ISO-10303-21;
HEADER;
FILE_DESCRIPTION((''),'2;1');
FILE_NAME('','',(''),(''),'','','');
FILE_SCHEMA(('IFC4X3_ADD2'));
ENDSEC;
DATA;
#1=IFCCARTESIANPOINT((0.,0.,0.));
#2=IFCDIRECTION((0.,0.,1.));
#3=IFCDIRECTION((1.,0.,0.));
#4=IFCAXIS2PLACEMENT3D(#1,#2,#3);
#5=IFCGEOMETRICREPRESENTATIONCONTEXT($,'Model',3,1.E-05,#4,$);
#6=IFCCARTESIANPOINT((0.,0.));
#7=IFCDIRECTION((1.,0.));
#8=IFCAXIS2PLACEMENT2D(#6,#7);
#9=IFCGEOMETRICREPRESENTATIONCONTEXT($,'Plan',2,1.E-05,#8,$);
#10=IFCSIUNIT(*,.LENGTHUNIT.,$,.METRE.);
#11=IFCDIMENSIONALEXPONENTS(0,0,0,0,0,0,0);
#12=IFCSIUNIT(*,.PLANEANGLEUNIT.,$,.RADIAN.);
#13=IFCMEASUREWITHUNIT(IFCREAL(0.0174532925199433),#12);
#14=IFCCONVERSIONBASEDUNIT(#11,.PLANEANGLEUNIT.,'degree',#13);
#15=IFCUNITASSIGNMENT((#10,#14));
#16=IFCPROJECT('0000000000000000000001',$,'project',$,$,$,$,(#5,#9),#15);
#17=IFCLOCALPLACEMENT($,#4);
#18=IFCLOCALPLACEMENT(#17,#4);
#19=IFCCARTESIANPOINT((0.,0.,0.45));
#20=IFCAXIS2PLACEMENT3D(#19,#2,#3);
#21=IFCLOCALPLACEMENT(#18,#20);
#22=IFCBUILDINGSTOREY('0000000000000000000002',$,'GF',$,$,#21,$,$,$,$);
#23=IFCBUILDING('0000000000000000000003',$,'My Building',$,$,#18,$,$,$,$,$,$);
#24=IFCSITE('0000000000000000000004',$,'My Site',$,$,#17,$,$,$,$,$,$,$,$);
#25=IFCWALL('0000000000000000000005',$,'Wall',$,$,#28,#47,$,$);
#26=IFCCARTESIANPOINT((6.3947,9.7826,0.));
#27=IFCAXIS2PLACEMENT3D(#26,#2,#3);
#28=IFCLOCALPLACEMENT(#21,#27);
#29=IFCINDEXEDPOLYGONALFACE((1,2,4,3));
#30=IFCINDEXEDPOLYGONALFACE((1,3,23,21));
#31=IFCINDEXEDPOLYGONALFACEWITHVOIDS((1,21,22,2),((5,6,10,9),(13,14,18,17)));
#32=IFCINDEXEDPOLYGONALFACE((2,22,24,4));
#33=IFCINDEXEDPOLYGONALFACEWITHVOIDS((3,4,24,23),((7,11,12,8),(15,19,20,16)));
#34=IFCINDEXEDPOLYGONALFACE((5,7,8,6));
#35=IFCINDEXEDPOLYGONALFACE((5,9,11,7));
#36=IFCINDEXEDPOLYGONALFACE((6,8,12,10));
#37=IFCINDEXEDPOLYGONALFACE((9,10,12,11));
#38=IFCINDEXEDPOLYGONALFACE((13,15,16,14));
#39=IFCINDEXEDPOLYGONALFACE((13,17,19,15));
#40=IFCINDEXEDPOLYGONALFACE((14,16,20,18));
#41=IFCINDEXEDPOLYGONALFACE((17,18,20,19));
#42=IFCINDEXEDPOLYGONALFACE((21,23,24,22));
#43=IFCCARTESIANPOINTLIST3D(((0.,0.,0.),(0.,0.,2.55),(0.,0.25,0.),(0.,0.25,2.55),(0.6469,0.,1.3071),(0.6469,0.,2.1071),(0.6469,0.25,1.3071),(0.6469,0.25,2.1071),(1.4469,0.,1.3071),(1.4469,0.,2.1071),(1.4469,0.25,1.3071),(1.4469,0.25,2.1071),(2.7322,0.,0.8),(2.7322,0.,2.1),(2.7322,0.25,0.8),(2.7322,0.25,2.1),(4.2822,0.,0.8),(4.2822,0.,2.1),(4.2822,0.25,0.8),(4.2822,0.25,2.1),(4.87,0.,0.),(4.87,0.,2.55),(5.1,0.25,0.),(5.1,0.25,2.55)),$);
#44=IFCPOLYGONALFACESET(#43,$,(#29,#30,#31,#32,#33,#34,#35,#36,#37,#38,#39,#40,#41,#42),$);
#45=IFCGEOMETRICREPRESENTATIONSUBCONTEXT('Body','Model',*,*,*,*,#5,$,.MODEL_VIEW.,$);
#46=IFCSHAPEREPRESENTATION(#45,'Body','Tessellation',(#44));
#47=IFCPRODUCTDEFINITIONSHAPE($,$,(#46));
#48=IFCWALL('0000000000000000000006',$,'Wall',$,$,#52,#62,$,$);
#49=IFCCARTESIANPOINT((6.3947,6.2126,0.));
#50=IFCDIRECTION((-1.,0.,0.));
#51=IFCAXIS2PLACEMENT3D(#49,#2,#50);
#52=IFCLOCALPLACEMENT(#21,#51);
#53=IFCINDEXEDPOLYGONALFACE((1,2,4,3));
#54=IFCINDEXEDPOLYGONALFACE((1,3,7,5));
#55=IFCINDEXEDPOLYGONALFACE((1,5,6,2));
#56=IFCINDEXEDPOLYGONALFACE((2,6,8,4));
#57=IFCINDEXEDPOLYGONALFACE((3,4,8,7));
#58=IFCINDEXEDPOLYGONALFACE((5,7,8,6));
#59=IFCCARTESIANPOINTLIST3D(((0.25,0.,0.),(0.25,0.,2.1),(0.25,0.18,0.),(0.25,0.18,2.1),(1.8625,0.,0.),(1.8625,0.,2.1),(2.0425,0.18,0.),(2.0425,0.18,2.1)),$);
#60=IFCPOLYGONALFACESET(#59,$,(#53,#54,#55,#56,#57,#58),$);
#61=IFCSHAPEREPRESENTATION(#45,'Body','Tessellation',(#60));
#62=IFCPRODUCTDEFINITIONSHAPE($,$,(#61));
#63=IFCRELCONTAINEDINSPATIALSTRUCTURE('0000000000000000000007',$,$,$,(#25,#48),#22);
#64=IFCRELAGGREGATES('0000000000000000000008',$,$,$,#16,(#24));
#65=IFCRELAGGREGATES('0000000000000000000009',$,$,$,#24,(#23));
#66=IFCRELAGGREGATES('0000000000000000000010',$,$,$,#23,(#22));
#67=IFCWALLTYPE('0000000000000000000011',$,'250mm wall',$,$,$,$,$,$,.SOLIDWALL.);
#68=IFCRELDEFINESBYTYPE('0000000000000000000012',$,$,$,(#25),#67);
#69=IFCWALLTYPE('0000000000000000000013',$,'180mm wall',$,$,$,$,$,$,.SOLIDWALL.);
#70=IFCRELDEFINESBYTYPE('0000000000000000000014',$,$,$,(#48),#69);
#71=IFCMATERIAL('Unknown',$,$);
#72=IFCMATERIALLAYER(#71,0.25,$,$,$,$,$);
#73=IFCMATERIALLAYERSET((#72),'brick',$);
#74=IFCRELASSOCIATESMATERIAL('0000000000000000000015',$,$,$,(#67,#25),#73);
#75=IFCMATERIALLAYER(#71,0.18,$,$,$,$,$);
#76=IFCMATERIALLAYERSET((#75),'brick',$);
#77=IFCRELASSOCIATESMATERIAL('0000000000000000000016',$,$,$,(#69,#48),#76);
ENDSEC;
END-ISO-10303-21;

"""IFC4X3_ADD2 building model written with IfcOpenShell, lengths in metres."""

from ifc_helpers import new_model, entity, si_unit, converted_unit, frame, origin_with_axes, origin_2d_with_axis, place, context, subcontext, project, spatial, line, indexed_curve, outline, extrude, source, transform, mapped, material, layer, layer_set, layer_usage, type_object, element, save


model = new_model("IFC4X3_ADD2")

# Units and contexts
model_context = context("Model", 3, precision=1e-05, world=origin_with_axes())
plan_context = context("Plan", 2, precision=1e-05, world=origin_2d_with_axis())
body_context_1 = subcontext(model_context, "Body", "Model", "MODEL_VIEW")
ifc_project = project(units=[si_unit("LENGTHUNIT", "METRE"), converted_unit("PLANEANGLEUNIT", "degree", entity("IfcReal", 0.0174532925199433), si_unit("PLANEANGLEUNIT", "RADIAN"), dimensions=[0, 0, 0, 0, 0, 0, 0])], contexts=[model_context, plan_context])

# Site, building, storey
site_placement = place(None, origin_with_axes())
site = spatial("IfcSite", under=ifc_project, at=site_placement, Name="My Site")
building_placement = place(site_placement, origin_with_axes())
building = spatial("IfcBuilding", under=site, at=building_placement, Name="My Building")
storey_placement = place(building_placement, frame((0.0, 0.0, 0.45), z_axis=(0.0, 0.0, 1.0), x_axis=(1.0, 0.0, 0.0)))
storey = spatial("IfcBuildingStorey", under=building, at=storey_placement, Name="GF")

# Wall, openings
ifc_material_1 = material(Name="Unknown")
ifc_layer_1 = layer(ifc_material_1, 0.25)
ifc_layer_set_1 = layer_set([ifc_layer_1], Name="brick")
ifc_layer_usage_1 = layer_usage(ifc_layer_set_1, "AXIS2", "POSITIVE", 0.0)
wall_type_1 = type_object("IfcWallType", Name="250mm wall", PredefinedType="SOLIDWALL", material=ifc_layer_set_1)
wall_1_placement = place(storey_placement, frame((6.3947, 9.7826, 0.0), z_axis=(0.0, 0.0, 1.0), x_axis=(1.0, 0.0, 0.0)))
wall_1 = element("IfcWall", 1, at=wall_1_placement, inside=storey, type_object=wall_type_1, material=ifc_layer_usage_1, Name="Wall", context=body_context_1, shape_type="SweptSolid", body=[
    extrude(outline(indexed_curve([(0.0, 0.0), (0.0, 0.25), (5.1, 0.25), (4.87, 0.0)], segments=[line(1, 2, 3, 4, 1)])), origin_with_axes(), (0.0, 0.0, 1.0), 2.55),
])
shared_shape_1 = source(origin_with_axes(), body_context_1, "Body", "SweptSolid", [
    extrude(outline(indexed_curve([(0.0, 0.0), (1.55, 0.0), (1.55, 1.3), (0.0, 1.3)], segments=[line(1, 2, 3, 4, 1)])), frame((-0.775, -0.6, 0.0), z_axis=(0.0, -1.0, 0.0), x_axis=(1.0, 0.0, 0.0)), (0.0, 0.0, -1.0), 1.2),
])
opening_1_placement = place(wall_1_placement, frame((3.5072, 0.2257, 0.8), z_axis=(0.0, 0.0, 1.0), x_axis=(-1.0, 0.0, 0.0)))
element("IfcOpeningElement", 2, at=opening_1_placement, cuts=wall_1, PredefinedType="OPENING", context=body_context_1, shape_type="MappedRepresentation", body=[
    mapped(shared_shape_1, transform((0.0, 0.0, 0.0), x_axis=(1.0, 0.0, 0.0), y_axis=(0.0, 1.0, 0.0), z_axis=(0.0, 0.0, 1.0), scale=1.0)),
])
shared_shape_2 = source(origin_with_axes(), body_context_1, "Body", "SweptSolid", [
    extrude(outline(indexed_curve([(0.0, 0.0), (0.8, 0.0), (0.8, 0.8), (0.0, 0.8)], segments=[line(1, 2, 3, 4, 1)])), frame((-0.4, -0.6, 0.0), z_axis=(0.0, -1.0, 0.0), x_axis=(1.0, 0.0, 0.0)), (0.0, 0.0, -1.0), 1.2),
])
opening_2_placement = place(wall_1_placement, frame((1.0469, 0.0, 1.3071), z_axis=(0.0, 0.0, 1.0), x_axis=(1.0, 0.0, 0.0)))
element("IfcOpeningElement", 3, at=opening_2_placement, cuts=wall_1, PredefinedType="OPENING", context=body_context_1, shape_type="MappedRepresentation", body=[
    mapped(shared_shape_2, transform((0.0, 0.0, 0.0), x_axis=(1.0, 0.0, 0.0), y_axis=(0.0, 1.0, 0.0), z_axis=(0.0, 0.0, 1.0), scale=1.0)),
])

# Shared definitions
ifc_layer_2 = layer(ifc_material_1, 0.18)
ifc_layer_set_2 = layer_set([ifc_layer_2], Name="brick")
wall_type_2 = type_object("IfcWallType", Name="180mm wall", PredefinedType="SOLIDWALL", material=ifc_layer_set_2)

# Wall
ifc_layer_usage_2 = layer_usage(ifc_layer_set_2, "AXIS2", "POSITIVE", 0.0)
wall_2_placement = place(storey_placement, frame((6.3947, 6.2126, 0.0), z_axis=(0.0, 0.0, 1.0), x_axis=(-1.0, 0.0, 0.0)))
element("IfcWall", 4, at=wall_2_placement, inside=storey, type_object=wall_type_2, material=ifc_layer_usage_2, Name="Wall", context=body_context_1, shape_type="SweptSolid", body=[
    extrude(outline(indexed_curve([(0.25, 0.0), (0.25, 0.18), (2.0425, 0.18), (1.8625, 0.0)], segments=[line(1, 2, 3, 4, 1)])), origin_with_axes(), (0.0, 0.0, 1.0), 2.1),
])

save(model, "model.ifc")
